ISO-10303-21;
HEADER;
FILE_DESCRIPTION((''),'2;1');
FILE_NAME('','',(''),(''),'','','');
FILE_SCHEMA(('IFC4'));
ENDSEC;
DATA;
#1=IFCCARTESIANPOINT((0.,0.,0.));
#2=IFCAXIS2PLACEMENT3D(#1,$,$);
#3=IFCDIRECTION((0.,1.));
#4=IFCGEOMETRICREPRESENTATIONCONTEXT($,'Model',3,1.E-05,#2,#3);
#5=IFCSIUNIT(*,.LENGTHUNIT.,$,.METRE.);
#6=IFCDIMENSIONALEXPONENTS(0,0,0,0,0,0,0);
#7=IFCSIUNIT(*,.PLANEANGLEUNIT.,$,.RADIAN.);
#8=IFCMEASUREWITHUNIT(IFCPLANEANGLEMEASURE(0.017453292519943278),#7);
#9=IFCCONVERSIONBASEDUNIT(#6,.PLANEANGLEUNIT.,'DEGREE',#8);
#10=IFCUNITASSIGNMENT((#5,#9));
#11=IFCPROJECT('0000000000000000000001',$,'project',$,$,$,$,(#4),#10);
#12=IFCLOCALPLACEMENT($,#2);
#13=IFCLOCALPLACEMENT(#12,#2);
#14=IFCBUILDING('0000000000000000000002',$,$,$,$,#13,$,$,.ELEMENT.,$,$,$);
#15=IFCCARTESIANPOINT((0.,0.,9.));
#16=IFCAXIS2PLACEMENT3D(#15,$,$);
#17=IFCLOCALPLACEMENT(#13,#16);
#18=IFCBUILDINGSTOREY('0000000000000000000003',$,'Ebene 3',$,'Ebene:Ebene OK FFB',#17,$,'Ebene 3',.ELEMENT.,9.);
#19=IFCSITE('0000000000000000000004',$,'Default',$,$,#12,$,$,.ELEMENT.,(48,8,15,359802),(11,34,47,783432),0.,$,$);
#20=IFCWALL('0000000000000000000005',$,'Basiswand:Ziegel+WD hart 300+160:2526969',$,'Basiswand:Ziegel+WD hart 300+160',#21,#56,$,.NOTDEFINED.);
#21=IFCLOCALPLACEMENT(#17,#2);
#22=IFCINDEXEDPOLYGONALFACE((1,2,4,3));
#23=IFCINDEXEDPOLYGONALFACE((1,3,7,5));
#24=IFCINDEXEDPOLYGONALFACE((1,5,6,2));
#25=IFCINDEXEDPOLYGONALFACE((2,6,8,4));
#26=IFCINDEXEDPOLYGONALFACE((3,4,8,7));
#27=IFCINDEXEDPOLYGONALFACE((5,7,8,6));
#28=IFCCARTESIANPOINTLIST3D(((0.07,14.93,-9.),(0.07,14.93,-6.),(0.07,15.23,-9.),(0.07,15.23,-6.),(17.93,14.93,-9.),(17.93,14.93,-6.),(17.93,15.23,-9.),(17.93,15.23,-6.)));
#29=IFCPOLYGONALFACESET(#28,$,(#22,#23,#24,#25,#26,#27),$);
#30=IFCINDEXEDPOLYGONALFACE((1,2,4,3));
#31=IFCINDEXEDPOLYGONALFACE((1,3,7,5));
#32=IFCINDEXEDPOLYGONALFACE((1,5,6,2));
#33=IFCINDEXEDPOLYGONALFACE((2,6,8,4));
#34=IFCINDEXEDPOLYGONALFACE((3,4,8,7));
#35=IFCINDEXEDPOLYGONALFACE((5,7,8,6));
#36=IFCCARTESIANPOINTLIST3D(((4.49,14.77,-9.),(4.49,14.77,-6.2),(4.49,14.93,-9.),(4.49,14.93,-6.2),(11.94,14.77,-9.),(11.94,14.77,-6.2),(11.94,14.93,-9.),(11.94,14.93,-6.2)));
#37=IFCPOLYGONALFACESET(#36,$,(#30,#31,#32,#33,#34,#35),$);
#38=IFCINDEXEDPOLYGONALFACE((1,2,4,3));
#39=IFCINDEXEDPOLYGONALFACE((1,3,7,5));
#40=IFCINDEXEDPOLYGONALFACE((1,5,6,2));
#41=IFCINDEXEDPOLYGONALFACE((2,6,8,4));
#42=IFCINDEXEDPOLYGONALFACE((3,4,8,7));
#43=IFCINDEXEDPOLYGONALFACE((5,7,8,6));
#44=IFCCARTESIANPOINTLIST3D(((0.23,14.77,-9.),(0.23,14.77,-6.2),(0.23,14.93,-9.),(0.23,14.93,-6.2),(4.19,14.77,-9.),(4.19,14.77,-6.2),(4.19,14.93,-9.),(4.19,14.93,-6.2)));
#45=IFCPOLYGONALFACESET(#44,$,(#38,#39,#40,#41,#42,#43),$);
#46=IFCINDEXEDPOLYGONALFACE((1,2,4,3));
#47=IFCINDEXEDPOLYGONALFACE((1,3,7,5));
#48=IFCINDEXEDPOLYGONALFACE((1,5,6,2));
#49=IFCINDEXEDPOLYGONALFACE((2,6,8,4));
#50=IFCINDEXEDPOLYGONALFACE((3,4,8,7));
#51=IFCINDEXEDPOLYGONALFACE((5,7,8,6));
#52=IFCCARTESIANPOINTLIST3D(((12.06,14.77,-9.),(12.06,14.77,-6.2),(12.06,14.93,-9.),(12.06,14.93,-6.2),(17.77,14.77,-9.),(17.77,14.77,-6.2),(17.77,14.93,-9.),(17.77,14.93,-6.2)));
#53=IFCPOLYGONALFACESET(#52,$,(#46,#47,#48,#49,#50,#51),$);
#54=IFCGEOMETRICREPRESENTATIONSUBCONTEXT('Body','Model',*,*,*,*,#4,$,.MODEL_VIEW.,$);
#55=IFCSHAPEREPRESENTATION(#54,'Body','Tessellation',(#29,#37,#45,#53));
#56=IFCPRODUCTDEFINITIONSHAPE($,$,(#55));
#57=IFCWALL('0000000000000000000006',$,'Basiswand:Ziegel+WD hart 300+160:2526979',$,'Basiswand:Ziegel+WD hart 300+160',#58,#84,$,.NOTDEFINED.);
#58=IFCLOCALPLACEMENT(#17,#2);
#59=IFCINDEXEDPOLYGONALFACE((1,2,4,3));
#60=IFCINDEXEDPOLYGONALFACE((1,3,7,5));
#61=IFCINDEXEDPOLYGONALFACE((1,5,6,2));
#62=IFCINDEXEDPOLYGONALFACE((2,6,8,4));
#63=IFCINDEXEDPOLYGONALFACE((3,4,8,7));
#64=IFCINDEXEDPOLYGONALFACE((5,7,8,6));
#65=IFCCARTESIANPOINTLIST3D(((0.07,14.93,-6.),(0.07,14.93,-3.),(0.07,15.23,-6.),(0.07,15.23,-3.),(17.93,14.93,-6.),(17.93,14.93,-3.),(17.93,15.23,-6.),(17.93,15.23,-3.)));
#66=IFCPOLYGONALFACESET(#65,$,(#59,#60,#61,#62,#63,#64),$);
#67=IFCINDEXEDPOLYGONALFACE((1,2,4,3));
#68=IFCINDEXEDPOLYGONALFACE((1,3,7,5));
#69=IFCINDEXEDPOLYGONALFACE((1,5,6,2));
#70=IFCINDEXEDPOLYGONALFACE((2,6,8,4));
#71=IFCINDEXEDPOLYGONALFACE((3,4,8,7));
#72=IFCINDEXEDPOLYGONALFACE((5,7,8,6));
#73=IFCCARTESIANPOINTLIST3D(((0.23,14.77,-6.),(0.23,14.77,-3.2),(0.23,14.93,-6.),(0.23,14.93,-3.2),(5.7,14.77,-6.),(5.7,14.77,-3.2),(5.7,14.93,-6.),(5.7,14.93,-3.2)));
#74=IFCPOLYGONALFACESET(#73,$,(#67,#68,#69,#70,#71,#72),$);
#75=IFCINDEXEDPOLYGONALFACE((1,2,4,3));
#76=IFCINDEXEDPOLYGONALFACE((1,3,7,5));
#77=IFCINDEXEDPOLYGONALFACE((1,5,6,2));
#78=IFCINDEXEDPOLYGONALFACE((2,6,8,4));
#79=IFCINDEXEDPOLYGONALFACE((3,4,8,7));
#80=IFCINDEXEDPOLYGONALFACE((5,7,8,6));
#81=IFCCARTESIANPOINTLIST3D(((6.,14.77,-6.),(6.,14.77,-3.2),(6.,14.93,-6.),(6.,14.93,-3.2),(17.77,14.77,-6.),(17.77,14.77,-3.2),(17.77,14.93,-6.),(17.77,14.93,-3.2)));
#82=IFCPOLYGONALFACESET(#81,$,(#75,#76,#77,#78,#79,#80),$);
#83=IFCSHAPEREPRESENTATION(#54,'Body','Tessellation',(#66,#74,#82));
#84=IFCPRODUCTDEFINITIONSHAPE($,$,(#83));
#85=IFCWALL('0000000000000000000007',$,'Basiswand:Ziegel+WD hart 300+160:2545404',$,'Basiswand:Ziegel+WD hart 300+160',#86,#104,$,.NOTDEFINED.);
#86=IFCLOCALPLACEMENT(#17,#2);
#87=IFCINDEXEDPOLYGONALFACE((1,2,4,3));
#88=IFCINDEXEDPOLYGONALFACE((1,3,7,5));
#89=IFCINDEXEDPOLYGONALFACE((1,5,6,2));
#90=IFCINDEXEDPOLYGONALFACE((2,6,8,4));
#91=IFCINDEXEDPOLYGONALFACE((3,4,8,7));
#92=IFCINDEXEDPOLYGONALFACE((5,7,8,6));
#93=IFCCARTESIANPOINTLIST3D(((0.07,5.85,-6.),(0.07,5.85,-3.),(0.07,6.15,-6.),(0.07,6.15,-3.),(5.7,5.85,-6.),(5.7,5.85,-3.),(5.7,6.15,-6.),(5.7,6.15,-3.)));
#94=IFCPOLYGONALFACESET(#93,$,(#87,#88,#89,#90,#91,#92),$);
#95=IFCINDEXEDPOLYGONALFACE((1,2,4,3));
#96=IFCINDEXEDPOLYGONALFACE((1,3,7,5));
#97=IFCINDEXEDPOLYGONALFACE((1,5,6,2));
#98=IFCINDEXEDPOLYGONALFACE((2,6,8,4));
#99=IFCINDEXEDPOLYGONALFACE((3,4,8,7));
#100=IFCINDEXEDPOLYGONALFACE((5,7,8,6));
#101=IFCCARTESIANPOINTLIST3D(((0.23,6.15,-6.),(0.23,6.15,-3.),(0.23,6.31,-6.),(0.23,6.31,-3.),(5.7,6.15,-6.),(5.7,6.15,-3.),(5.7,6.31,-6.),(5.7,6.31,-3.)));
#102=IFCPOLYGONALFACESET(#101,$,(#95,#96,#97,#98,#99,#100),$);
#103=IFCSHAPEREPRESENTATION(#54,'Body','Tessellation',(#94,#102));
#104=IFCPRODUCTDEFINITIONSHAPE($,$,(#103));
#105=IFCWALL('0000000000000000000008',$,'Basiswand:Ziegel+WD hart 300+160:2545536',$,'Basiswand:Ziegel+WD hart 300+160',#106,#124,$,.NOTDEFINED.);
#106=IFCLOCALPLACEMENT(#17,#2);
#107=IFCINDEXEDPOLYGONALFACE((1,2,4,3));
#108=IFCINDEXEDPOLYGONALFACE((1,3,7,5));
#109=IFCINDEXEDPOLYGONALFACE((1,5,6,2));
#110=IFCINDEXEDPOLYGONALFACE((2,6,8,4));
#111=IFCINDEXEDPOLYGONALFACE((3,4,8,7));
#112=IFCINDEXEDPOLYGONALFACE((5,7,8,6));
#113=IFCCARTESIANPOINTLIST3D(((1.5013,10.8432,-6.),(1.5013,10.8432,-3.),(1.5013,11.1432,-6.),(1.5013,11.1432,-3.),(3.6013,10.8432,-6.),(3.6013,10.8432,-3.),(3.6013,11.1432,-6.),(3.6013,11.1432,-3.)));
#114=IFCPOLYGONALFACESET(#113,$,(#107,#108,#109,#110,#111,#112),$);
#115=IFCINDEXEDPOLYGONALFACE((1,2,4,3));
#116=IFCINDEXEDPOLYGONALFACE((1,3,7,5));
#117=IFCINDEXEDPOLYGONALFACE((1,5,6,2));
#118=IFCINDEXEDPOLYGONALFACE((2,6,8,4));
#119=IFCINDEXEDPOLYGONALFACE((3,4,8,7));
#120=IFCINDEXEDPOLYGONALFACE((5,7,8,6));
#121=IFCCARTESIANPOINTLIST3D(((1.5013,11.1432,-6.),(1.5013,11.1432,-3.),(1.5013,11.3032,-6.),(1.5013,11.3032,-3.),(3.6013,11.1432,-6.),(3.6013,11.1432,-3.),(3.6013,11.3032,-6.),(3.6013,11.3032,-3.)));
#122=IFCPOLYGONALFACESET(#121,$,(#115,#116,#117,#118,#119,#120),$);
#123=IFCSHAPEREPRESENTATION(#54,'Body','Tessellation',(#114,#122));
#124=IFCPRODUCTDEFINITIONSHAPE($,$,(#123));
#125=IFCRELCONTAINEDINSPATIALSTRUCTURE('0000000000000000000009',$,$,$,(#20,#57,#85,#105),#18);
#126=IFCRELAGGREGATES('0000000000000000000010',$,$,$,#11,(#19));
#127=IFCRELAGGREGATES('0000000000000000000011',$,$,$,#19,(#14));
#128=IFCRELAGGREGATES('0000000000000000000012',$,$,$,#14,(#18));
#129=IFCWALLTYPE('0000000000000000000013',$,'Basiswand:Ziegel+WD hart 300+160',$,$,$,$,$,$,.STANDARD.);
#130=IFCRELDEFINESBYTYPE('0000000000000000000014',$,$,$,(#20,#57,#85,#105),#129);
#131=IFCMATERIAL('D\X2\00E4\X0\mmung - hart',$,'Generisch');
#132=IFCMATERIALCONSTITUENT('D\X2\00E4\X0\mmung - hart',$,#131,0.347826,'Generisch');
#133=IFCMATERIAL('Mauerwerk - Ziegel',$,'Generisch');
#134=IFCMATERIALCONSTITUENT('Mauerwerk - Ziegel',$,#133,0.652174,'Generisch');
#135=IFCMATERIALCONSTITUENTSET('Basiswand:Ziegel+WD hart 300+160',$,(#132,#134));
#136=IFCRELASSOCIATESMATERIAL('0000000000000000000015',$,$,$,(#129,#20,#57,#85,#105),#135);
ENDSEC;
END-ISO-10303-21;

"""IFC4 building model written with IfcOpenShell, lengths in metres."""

from ifc_helpers import new_model, entity, si_unit, converted_unit, direction, frame, origin, place, context, subcontext, project, spatial, indexed_curve, outline, extrude, material, constituent, constituent_set, type_object, element, save


model = new_model("IFC4")

# Units and contexts
model_context = context("Model", 3, precision=1e-05, world=origin(), true_north=direction((0.0, 1.0)))
body_context = subcontext(model_context, "Body", "Model", "MODEL_VIEW")
ifc_project = project(units=[si_unit("LENGTHUNIT", "METRE"), converted_unit("PLANEANGLEUNIT", "DEGREE", entity("IfcPlaneAngleMeasure", 0.017453292519943278), si_unit("PLANEANGLEUNIT", "RADIAN"), dimensions=[0, 0, 0, 0, 0, 0, 0])], contexts=[model_context])

# Site, building, storey
site_placement = place(None, origin())
site = spatial("IfcSite", under=ifc_project, at=site_placement, Name="Default", CompositionType="ELEMENT", RefLatitude=(48, 8, 15, 359802), RefLongitude=(11, 34, 47, 783432), RefElevation=0.0)
building_placement = place(site_placement, origin())
building = spatial("IfcBuilding", under=site, at=building_placement, CompositionType="ELEMENT")
storey_placement = place(building_placement, frame((0.0, 0.0, 9.0)))
storey = spatial("IfcBuildingStorey", under=building, at=storey_placement, Name="Ebene 3", ObjectType="Ebene:Ebene OK FFB", LongName="Ebene 3", CompositionType="ELEMENT", Elevation=9.0)

# Walls
ifc_material_1 = material(Name="Dämmung - hart", Category="Generisch")
ifc_constituent_1 = constituent(ifc_material_1, Name="Dämmung - hart", Category="Generisch", fraction=0.347826)
ifc_material_2 = material(Name="Mauerwerk - Ziegel", Category="Generisch")
ifc_constituent_2 = constituent(ifc_material_2, Name="Mauerwerk - Ziegel", Category="Generisch", fraction=0.652174)
ifc_constituent_set_1 = constituent_set(constituents=[ifc_constituent_1, ifc_constituent_2], Name="Basiswand:Ziegel+WD hart 300+160")
wall_type = type_object("IfcWallType", Name="Basiswand:Ziegel+WD hart 300+160", PredefinedType="STANDARD", material=ifc_constituent_set_1)
wall_1_placement = place(storey_placement, frame((17.77, 15.0, -9.0), z_axis=(0.0, 0.0, 1.0), x_axis=(-1.0, 0.0, 0.0)))
element("IfcWall", 1, at=wall_1_placement, inside=storey, type_object=wall_type, material=ifc_constituent_set_1, Name="Basiswand:Ziegel+WD hart 300+160:2526969", ObjectType="Basiswand:Ziegel+WD hart 300+160", PredefinedType="NOTDEFINED", context=body_context, shape_type="SweptSolid", body=[
    extrude(outline(indexed_curve([(-0.15, -8.93), (0.15, -8.93), (0.15, 8.93), (-0.15, 8.93), (-0.15, -8.93)], self_intersect=False)), frame((8.77, -0.08, 0.0), z_axis=(0.0, 0.0, 1.0), x_axis=(0.0, 1.0, 0.0)), (0.0, 0.0, 1.0), 3.0),
    extrude(outline(indexed_curve([(-3.725, -0.08), (3.725, -0.08), (3.725, 0.08), (-3.725, 0.08), (-3.725, -0.08)], self_intersect=False)), frame((9.555, 0.15, 0.0)), (0.0, 0.0, 1.0), 2.8),
    extrude(outline(indexed_curve([(-1.98, -0.08), (1.98, -0.08), (1.98, 0.08), (-1.98, 0.08), (-1.98, -0.08)], self_intersect=False)), frame((15.56, 0.15, 0.0), z_axis=(0.0, 0.0, 1.0), x_axis=(-1.0, 0.0, 0.0)), (0.0, 0.0, 1.0), 2.8),
    extrude(outline(indexed_curve([(-2.855, -0.08), (2.855, -0.08), (2.855, 0.08), (-2.855, 0.08), (-2.855, -0.08)], self_intersect=False)), frame((2.855, 0.15, 0.0)), (0.0, 0.0, 1.0), 2.8),
])
wall_2_placement = place(storey_placement, frame((17.77, 15.0, -6.0), z_axis=(0.0, 0.0, 1.0), x_axis=(-1.0, 0.0, 0.0)))
element("IfcWall", 2, at=wall_2_placement, inside=storey, type_object=wall_type, material=ifc_constituent_set_1, Name="Basiswand:Ziegel+WD hart 300+160:2526979", ObjectType="Basiswand:Ziegel+WD hart 300+160", PredefinedType="NOTDEFINED", context=body_context, shape_type="SweptSolid", body=[
    extrude(outline(indexed_curve([(-0.15, -8.93), (0.15, -8.93), (0.15, 8.93), (-0.15, 8.93), (-0.15, -8.93)], self_intersect=False)), frame((8.77, -0.08, 0.0), z_axis=(0.0, 0.0, 1.0), x_axis=(0.0, 1.0, 0.0)), (0.0, 0.0, 1.0), 3.0),
    extrude(outline(indexed_curve([(-2.735, -0.08), (2.735, -0.08), (2.735, 0.08), (-2.735, 0.08), (-2.735, -0.08)], self_intersect=False)), frame((14.805, 0.15, 0.0), z_axis=(0.0, 0.0, 1.0), x_axis=(-1.0, 0.0, 0.0)), (0.0, 0.0, 1.0), 2.8),
    extrude(outline(indexed_curve([(-5.885, -0.08), (5.885, -0.08), (5.885, 0.08), (-5.885, 0.08), (-5.885, -0.08)], self_intersect=False)), frame((5.885, 0.15, 0.0)), (0.0, 0.0, 1.0), 2.8),
])

# Walls
wall_3_placement = place(storey_placement, frame((0.23, 6.08, -6.0)))
element("IfcWall", 3, at=wall_3_placement, inside=storey, type_object=wall_type, material=ifc_constituent_set_1, Name="Basiswand:Ziegel+WD hart 300+160:2545404", ObjectType="Basiswand:Ziegel+WD hart 300+160", PredefinedType="NOTDEFINED", context=body_context, shape_type="SweptSolid", body=[
    extrude(outline(indexed_curve([(-0.15, -2.815), (0.15, -2.815), (0.15, 2.815), (-0.15, 2.815), (-0.15, -2.815)], self_intersect=False)), frame((2.655, -0.08, 0.0), z_axis=(0.0, 0.0, 1.0), x_axis=(0.0, 1.0, 0.0)), (0.0, 0.0, 1.0), 3.0),
    extrude(outline(indexed_curve([(-0.08, -2.735), (0.08, -2.735), (0.08, 2.735), (-0.08, 2.735), (-0.08, -2.735)], self_intersect=False)), frame((2.735, 0.15, 0.0), z_axis=(0.0, 0.0, 1.0), x_axis=(0.0, 1.0, 0.0)), (0.0, 0.0, 1.0), 3.0),
])
wall_4_placement = place(storey_placement, frame((1.5013, 11.0732, -6.0)))
element("IfcWall", 4, at=wall_4_placement, inside=storey, type_object=wall_type, material=ifc_constituent_set_1, Name="Basiswand:Ziegel+WD hart 300+160:2545536", ObjectType="Basiswand:Ziegel+WD hart 300+160", PredefinedType="NOTDEFINED", context=body_context, shape_type="SweptSolid", body=[
    extrude(outline(indexed_curve([(-0.15, -1.05), (0.15, -1.05), (0.15, 1.05), (-0.15, 1.05), (-0.15, -1.05)], self_intersect=False)), frame((1.05, -0.08, 0.0), z_axis=(0.0, 0.0, 1.0), x_axis=(0.0, 1.0, 0.0)), (0.0, 0.0, 1.0), 3.0),
    extrude(outline(indexed_curve([(-0.08, -1.05), (0.08, -1.05), (0.08, 1.05), (-0.08, 1.05), (-0.08, -1.05)], self_intersect=False)), frame((1.05, 0.15, 0.0), z_axis=(0.0, 0.0, 1.0), x_axis=(0.0, -1.0, 0.0)), (0.0, 0.0, 1.0), 3.0),
])

save(model, "model.ifc")
